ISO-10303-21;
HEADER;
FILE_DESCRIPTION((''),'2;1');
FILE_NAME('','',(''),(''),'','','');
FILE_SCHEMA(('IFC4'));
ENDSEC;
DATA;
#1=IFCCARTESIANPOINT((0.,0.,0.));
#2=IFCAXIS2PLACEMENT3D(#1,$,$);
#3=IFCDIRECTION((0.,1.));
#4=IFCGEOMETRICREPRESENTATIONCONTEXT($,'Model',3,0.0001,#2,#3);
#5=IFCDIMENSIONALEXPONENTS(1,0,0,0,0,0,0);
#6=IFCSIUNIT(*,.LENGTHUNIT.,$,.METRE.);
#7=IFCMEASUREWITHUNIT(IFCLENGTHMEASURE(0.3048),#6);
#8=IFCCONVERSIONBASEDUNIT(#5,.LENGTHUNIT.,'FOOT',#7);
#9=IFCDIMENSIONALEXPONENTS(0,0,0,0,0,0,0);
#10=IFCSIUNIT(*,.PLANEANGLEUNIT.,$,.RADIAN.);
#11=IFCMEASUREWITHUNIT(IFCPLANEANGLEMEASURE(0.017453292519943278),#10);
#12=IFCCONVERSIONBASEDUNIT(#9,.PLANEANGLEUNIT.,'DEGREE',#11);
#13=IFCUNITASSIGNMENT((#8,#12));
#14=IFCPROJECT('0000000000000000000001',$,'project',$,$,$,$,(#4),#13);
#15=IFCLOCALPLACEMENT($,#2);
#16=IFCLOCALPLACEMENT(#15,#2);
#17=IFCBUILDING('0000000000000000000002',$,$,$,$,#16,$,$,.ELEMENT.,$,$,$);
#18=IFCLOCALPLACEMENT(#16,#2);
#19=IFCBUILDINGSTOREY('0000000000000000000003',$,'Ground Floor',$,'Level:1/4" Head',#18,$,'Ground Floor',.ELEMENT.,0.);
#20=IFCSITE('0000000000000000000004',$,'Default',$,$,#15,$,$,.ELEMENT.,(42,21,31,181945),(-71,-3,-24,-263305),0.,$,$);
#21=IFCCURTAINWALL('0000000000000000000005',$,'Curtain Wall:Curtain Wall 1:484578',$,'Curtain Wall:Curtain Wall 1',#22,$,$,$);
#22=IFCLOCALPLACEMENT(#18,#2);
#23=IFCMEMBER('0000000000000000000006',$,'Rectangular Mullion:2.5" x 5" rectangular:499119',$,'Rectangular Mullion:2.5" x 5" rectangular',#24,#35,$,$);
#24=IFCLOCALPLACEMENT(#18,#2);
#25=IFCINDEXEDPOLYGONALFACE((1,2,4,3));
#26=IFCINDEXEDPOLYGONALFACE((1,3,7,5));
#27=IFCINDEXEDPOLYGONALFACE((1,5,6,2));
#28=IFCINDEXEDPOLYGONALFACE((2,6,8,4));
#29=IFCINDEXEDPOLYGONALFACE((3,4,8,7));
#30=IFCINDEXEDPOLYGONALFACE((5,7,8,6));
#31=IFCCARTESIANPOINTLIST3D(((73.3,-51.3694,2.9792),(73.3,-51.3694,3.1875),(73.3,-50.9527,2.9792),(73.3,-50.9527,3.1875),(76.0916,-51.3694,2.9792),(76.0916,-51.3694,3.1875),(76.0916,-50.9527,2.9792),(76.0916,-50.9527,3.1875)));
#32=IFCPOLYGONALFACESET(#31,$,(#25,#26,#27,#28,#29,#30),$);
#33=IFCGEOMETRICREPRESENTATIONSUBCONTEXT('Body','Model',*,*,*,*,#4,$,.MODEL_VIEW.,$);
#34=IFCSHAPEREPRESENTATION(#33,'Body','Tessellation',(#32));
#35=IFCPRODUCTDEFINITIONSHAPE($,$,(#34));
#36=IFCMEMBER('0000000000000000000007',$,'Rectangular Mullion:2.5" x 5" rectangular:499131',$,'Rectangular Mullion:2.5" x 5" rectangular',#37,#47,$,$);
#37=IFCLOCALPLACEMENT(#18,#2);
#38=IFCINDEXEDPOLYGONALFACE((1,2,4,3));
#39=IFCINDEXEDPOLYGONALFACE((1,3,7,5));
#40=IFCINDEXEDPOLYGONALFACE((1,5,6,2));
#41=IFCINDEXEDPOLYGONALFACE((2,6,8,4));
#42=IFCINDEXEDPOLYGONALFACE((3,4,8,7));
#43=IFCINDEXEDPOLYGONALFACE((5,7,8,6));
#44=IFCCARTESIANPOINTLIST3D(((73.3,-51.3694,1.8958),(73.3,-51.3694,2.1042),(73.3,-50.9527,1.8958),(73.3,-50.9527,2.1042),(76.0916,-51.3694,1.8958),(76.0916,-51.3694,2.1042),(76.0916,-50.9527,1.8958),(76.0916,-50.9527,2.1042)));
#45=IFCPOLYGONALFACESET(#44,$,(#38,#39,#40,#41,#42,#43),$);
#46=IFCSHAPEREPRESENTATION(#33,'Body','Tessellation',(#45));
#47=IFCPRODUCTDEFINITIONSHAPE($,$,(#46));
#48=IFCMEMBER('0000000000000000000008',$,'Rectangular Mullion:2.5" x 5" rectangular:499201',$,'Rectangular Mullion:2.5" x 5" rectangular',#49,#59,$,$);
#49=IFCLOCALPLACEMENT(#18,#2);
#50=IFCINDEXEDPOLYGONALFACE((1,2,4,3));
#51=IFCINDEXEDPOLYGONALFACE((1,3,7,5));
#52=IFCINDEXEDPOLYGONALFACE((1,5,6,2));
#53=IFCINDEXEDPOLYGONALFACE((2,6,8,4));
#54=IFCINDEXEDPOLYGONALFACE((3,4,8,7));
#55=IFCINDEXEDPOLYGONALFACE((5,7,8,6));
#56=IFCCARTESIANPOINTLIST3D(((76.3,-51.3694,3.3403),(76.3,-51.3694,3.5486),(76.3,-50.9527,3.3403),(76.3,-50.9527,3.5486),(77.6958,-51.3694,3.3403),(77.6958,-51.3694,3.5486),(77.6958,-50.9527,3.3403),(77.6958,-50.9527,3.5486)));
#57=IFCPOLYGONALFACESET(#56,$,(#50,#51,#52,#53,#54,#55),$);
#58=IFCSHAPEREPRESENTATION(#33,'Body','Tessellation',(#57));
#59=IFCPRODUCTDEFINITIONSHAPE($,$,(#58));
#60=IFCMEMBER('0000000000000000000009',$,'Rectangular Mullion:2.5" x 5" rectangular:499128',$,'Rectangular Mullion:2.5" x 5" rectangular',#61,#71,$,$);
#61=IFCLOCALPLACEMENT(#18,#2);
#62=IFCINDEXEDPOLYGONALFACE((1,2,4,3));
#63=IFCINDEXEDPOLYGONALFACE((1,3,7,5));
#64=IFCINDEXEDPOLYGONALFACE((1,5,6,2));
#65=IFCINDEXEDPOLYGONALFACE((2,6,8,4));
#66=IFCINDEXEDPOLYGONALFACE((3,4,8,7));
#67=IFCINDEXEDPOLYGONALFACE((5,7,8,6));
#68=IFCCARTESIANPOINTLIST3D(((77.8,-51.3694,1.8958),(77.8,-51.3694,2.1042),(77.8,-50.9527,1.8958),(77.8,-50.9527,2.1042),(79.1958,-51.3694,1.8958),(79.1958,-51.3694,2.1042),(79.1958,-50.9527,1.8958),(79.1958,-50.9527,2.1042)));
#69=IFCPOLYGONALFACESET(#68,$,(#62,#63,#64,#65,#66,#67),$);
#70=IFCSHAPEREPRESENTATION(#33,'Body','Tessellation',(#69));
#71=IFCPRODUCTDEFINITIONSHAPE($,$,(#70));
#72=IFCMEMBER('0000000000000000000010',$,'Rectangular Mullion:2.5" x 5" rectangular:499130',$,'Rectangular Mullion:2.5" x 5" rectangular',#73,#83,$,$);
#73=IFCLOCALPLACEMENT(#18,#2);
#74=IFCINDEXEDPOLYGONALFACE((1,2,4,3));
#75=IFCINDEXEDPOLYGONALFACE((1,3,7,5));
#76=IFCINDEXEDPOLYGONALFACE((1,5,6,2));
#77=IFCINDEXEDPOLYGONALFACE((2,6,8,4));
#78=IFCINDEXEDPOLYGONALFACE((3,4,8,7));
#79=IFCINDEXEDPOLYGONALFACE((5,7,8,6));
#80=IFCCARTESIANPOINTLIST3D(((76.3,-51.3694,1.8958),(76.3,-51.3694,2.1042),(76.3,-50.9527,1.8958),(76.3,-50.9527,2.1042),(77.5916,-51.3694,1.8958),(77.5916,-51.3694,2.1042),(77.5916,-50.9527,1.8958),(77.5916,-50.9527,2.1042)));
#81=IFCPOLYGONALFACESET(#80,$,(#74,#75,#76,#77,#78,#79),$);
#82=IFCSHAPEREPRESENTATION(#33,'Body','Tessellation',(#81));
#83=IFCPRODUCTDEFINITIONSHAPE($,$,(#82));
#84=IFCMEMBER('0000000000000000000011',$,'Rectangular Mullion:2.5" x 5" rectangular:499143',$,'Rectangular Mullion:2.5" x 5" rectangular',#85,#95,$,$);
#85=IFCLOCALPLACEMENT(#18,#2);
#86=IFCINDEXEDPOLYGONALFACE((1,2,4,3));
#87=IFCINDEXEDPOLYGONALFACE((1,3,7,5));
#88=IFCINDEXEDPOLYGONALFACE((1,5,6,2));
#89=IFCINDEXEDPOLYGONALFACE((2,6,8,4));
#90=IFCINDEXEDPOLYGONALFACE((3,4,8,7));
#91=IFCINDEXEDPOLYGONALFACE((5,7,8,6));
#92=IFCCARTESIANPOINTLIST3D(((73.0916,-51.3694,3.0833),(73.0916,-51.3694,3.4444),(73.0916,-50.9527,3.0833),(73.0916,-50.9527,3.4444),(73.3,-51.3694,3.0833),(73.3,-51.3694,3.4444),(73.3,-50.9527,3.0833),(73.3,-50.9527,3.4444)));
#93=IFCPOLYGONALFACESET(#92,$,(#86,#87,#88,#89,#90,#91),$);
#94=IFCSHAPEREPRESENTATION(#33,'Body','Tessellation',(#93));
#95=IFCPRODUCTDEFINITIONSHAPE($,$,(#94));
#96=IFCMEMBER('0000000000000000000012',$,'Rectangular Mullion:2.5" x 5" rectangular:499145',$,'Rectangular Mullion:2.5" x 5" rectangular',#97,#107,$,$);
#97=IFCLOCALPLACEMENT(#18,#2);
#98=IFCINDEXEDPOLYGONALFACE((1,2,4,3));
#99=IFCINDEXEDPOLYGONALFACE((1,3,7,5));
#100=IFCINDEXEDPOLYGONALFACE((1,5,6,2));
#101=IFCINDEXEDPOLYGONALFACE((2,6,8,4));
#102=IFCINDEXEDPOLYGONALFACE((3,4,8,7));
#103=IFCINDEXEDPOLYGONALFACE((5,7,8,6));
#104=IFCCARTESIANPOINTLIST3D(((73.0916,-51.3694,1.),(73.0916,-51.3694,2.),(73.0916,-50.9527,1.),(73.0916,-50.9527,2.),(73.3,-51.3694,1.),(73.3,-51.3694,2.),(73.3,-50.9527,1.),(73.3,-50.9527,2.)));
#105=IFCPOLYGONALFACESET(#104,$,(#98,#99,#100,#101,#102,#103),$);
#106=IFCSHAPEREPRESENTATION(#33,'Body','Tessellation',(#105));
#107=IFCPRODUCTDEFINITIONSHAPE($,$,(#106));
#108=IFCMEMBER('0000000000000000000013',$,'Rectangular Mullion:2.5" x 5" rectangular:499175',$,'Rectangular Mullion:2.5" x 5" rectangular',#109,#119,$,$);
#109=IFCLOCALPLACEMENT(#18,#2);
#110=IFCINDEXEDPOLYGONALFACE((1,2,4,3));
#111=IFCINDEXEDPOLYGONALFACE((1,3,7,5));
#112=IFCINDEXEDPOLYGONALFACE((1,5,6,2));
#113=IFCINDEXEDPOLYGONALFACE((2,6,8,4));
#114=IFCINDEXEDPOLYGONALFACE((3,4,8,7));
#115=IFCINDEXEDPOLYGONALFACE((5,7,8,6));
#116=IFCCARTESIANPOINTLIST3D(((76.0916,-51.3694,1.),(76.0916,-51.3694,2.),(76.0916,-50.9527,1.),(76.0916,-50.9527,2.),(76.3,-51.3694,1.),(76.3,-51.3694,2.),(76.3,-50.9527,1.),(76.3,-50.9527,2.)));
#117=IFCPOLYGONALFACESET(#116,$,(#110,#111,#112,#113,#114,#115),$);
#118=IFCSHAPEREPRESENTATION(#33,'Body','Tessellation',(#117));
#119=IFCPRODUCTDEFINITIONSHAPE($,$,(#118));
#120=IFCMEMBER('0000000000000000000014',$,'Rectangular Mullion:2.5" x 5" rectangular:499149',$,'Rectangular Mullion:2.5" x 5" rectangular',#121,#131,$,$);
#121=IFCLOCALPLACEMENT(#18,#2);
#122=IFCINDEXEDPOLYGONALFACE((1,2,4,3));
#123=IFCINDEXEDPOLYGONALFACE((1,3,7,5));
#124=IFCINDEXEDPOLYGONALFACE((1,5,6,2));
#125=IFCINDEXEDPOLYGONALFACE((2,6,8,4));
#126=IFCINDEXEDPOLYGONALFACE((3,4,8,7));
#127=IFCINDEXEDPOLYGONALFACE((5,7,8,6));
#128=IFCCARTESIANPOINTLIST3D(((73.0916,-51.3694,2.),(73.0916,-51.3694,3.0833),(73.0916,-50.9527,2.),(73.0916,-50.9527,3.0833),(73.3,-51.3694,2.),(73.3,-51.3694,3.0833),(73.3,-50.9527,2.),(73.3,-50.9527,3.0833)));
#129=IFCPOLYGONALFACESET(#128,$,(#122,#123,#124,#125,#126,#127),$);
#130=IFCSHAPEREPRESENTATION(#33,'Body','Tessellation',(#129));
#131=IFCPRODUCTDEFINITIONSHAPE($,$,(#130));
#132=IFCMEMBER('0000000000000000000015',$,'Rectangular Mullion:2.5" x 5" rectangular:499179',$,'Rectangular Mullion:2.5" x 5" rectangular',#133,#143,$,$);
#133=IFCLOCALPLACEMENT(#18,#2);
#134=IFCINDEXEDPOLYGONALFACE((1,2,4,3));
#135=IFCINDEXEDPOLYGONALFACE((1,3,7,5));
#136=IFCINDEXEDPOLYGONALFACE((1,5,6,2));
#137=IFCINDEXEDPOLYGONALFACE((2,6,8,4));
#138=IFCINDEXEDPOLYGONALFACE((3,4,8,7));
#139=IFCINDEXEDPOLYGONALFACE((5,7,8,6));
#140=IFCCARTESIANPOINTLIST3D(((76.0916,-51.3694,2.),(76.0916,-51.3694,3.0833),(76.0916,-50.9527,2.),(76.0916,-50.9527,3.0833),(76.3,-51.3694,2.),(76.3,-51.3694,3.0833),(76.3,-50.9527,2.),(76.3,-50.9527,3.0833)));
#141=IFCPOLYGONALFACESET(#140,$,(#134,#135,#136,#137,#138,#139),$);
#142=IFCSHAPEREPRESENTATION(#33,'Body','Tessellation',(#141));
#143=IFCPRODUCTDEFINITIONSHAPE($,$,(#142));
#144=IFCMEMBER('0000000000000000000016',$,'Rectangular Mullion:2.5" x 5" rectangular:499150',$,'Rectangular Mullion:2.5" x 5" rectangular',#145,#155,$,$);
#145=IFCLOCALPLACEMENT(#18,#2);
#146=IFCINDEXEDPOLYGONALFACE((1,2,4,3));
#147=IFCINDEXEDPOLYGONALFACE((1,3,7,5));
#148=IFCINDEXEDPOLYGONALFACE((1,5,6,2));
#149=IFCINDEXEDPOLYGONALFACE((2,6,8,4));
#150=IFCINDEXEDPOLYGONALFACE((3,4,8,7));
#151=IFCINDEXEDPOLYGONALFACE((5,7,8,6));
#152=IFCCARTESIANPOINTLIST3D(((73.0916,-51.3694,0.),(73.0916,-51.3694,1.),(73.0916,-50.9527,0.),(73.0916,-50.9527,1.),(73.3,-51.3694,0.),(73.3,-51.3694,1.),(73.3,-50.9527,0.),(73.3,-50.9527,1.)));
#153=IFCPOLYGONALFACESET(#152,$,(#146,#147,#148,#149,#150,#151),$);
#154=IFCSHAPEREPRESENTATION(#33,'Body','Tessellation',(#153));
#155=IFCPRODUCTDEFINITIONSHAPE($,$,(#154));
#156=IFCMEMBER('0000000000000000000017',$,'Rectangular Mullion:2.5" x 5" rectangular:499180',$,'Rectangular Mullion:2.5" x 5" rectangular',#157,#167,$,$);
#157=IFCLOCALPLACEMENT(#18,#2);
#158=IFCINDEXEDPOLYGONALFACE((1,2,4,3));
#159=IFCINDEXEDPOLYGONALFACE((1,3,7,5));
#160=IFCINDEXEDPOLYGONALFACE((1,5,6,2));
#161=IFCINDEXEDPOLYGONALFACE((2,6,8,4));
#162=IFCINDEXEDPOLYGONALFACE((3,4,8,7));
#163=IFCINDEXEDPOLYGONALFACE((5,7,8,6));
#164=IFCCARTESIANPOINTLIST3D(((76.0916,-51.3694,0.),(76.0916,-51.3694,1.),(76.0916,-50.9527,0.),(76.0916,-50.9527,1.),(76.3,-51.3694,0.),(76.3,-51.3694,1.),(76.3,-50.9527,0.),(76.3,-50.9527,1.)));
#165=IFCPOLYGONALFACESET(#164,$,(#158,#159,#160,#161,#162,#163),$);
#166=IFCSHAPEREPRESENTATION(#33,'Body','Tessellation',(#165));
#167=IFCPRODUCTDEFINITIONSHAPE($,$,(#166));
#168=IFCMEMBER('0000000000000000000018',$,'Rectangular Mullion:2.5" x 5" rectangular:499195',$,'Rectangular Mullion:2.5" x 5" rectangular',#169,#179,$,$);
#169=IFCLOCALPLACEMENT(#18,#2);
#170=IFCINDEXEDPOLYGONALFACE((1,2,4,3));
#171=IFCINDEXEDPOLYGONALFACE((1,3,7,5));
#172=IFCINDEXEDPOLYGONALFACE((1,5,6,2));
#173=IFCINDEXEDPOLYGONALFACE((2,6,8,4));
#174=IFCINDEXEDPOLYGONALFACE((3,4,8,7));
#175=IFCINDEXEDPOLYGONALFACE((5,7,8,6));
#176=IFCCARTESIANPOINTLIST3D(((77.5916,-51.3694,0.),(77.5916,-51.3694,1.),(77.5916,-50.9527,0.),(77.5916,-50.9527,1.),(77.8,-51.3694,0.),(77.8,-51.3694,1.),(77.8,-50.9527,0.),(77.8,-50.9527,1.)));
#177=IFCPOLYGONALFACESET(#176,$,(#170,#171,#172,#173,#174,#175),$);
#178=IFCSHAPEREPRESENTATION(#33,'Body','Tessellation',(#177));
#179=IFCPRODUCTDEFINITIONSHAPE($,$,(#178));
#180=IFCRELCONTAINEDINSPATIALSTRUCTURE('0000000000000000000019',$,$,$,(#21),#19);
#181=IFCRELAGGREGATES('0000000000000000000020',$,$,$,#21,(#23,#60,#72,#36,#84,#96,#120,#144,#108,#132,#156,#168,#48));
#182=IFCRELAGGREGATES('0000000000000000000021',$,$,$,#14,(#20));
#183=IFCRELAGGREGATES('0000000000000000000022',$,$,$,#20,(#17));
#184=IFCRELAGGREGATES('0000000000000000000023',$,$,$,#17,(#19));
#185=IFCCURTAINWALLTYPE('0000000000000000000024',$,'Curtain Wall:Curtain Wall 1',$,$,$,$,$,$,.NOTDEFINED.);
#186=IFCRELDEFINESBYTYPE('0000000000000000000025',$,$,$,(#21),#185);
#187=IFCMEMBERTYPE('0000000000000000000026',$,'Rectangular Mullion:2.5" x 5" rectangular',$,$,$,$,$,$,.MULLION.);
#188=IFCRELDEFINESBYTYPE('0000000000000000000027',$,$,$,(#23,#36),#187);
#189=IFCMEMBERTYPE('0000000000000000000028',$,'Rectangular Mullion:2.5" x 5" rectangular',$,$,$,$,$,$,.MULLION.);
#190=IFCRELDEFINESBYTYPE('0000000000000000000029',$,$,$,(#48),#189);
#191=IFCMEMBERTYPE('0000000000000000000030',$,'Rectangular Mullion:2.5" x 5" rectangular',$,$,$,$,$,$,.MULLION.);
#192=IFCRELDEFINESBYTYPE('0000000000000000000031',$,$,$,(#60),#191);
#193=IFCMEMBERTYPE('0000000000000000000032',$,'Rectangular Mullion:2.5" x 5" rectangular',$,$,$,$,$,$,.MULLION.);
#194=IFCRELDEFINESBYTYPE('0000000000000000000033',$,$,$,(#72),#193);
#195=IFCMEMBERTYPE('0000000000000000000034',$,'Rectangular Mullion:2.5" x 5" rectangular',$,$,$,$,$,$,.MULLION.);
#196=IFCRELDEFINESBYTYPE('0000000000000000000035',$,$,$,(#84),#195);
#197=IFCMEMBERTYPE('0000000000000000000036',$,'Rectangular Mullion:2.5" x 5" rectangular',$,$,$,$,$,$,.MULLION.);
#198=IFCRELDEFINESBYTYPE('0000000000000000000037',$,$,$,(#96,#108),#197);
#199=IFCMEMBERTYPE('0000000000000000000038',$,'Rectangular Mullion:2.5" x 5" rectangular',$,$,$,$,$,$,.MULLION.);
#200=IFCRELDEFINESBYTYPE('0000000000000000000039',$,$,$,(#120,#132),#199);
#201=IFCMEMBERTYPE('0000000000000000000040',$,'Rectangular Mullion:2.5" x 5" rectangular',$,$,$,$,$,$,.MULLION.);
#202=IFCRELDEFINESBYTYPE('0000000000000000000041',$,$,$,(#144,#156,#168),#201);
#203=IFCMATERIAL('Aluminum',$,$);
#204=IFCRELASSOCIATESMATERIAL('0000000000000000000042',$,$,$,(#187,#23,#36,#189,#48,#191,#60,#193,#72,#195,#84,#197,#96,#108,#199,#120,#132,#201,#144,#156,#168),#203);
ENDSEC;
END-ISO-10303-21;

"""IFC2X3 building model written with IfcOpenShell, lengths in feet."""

from ifc_helpers import new_model, entity, si_unit, converted_unit, direction, frame, origin, origin_2d_with_axis, place, context, subcontext, project, spatial, rectangle, extrude, source, transform, mapped, material, type_object, type_shapes, element, aggregate, save


model = new_model("IFC2X3")

# Units and contexts
model_context = context("Model", 3, precision=0.0001, world=origin(), true_north=direction((0.0, 1.0)))
body_context = subcontext(model_context, "Body", "Model", "MODEL_VIEW")
ifc_project = project(units=[converted_unit("LENGTHUNIT", "FOOT", entity("IfcLengthMeasure", 0.3048), si_unit("LENGTHUNIT", "METRE"), dimensions=[1, 0, 0, 0, 0, 0, 0]), converted_unit("PLANEANGLEUNIT", "DEGREE", entity("IfcPlaneAngleMeasure", 0.017453292519943278), si_unit("PLANEANGLEUNIT", "RADIAN"), dimensions=[0, 0, 0, 0, 0, 0, 0])], contexts=[model_context])

# Site, building, storey
site_placement = place(None, origin())
site = spatial("IfcSite", under=ifc_project, at=site_placement, Name="Default", CompositionType="ELEMENT", RefLatitude=(42, 21, 31, 181945), RefLongitude=(-71, -3, -24, -263305), RefElevation=0.0)
building_placement = place(site_placement, origin())
building = spatial("IfcBuilding", under=site, at=building_placement, CompositionType="ELEMENT")
storey_placement = place(building_placement, origin())
storey = spatial("IfcBuildingStorey", under=building, at=storey_placement, Name="Ground Floor", ObjectType="Level:1/4\" Head", LongName="Ground Floor", CompositionType="ELEMENT", Elevation=0.0)

# Curtain wall, members
curtain_wall_type = type_object("IfcCurtainWallType", Name="Curtain Wall:Curtain Wall 1", PredefinedType="NOTDEFINED")
curtain_wall_placement = place(storey_placement, origin())
curtain_wall = element("IfcCurtainWall", 1, at=curtain_wall_placement, inside=storey, type_object=curtain_wall_type, Name="Curtain Wall:Curtain Wall 1:484578", ObjectType="Curtain Wall:Curtain Wall 1")
ifc_material_1 = material(Name="Aluminum")
member_type_1 = type_object("IfcMemberType", Name="Rectangular Mullion:2.5\" x 5\" rectangular", PredefinedType="MULLION", material=ifc_material_1)
shared_shape_1 = source(origin(), body_context, "Body", "SweptSolid", [
    extrude(rectangle(XDim=0.2083, YDim=0.4167, at=origin_2d_with_axis()), frame((0.0, 0.0, -2.7917), z_axis=(0.0, 0.0, 1.0), x_axis=(-1.0, 0.0, 0.0)), (0.0, 0.0, 1.0), 2.7917),
])
type_shapes(member_type_1, [shared_shape_1])
member_1_placement = place(curtain_wall_placement, frame((76.0916, -51.161, 3.0833), z_axis=(1.0, 0.0, 0.0), x_axis=(0.0, 0.0, 1.0)))
member_1 = element("IfcMember", 2, at=member_1_placement, type_object=member_type_1, material=ifc_material_1, Name="Rectangular Mullion:2.5\" x 5\" rectangular:499119", ObjectType="Rectangular Mullion:2.5\" x 5\" rectangular", context=body_context, shape_type="MappedRepresentation", body=[
    mapped(shared_shape_1, transform((0.0, 0.0, 0.0), scale=1.0)),
])
member_2_placement = place(curtain_wall_placement, frame((76.0916, -51.161, 2.0), z_axis=(1.0, 0.0, 0.0), x_axis=(0.0, 0.0, 1.0)))
member_2 = element("IfcMember", 3, at=member_2_placement, type_object=member_type_1, material=ifc_material_1, Name="Rectangular Mullion:2.5\" x 5\" rectangular:499131", ObjectType="Rectangular Mullion:2.5\" x 5\" rectangular", context=body_context, shape_type="MappedRepresentation", body=[
    mapped(shared_shape_1, transform((0.0, 0.0, 0.0), scale=1.0)),
])
member_type_2 = type_object("IfcMemberType", Name="Rectangular Mullion:2.5\" x 5\" rectangular", PredefinedType="MULLION", material=ifc_material_1)
shared_shape_2 = source(origin(), body_context, "Body", "SweptSolid", [
    extrude(rectangle(XDim=0.2083, YDim=0.4167, at=origin_2d_with_axis()), frame((0.0, 0.0, -1.3958), z_axis=(0.0, 0.0, 1.0), x_axis=(-1.0, 0.0, 0.0)), (0.0, 0.0, 1.0), 1.3958),
])
type_shapes(member_type_2, [shared_shape_2])
member_3_placement = place(curtain_wall_placement, frame((77.6958, -51.161, 3.4444), z_axis=(1.0, 0.0, 0.0), x_axis=(0.0, 0.0, 1.0)))
member_3 = element("IfcMember", 4, at=member_3_placement, type_object=member_type_2, material=ifc_material_1, Name="Rectangular Mullion:2.5\" x 5\" rectangular:499201", ObjectType="Rectangular Mullion:2.5\" x 5\" rectangular", context=body_context, shape_type="MappedRepresentation", body=[
    mapped(shared_shape_2, transform((0.0, 0.0, 0.0), scale=1.0)),
])
member_type_3 = type_object("IfcMemberType", Name="Rectangular Mullion:2.5\" x 5\" rectangular", PredefinedType="MULLION", material=ifc_material_1)
shared_shape_3 = source(origin(), body_context, "Body", "SweptSolid", [
    extrude(rectangle(XDim=0.2083, YDim=0.4167, at=origin_2d_with_axis()), frame((0.0, 0.0, -1.3958), z_axis=(0.0, 0.0, 1.0), x_axis=(-1.0, 0.0, 0.0)), (0.0, 0.0, 1.0), 1.3958),
])
type_shapes(member_type_3, [shared_shape_3])
member_4_placement = place(curtain_wall_placement, frame((79.1958, -51.161, 2.0), z_axis=(1.0, 0.0, 0.0), x_axis=(0.0, 0.0, 1.0)))
member_4 = element("IfcMember", 5, at=member_4_placement, type_object=member_type_3, material=ifc_material_1, Name="Rectangular Mullion:2.5\" x 5\" rectangular:499128", ObjectType="Rectangular Mullion:2.5\" x 5\" rectangular", context=body_context, shape_type="MappedRepresentation", body=[
    mapped(shared_shape_3, transform((0.0, 0.0, 0.0), scale=1.0)),
])
member_type_4 = type_object("IfcMemberType", Name="Rectangular Mullion:2.5\" x 5\" rectangular", PredefinedType="MULLION", material=ifc_material_1)
shared_shape_4 = source(origin(), body_context, "Body", "SweptSolid", [
    extrude(rectangle(XDim=0.2083, YDim=0.4167, at=origin_2d_with_axis()), frame((0.0, 0.0, -1.2917), z_axis=(0.0, 0.0, 1.0), x_axis=(-1.0, 0.0, 0.0)), (0.0, 0.0, 1.0), 1.2917),
])
type_shapes(member_type_4, [shared_shape_4])
member_5_placement = place(curtain_wall_placement, frame((77.5916, -51.161, 2.0), z_axis=(1.0, 0.0, 0.0), x_axis=(0.0, 0.0, 1.0)))
member_5 = element("IfcMember", 6, at=member_5_placement, type_object=member_type_4, material=ifc_material_1, Name="Rectangular Mullion:2.5\" x 5\" rectangular:499130", ObjectType="Rectangular Mullion:2.5\" x 5\" rectangular", context=body_context, shape_type="MappedRepresentation", body=[
    mapped(shared_shape_4, transform((0.0, 0.0, 0.0), scale=1.0)),
])
member_type_5 = type_object("IfcMemberType", Name="Rectangular Mullion:2.5\" x 5\" rectangular", PredefinedType="MULLION", material=ifc_material_1)
shared_shape_5 = source(origin(), body_context, "Body", "SweptSolid", [
    extrude(rectangle(XDim=0.2083, YDim=0.4167, at=origin_2d_with_axis()), frame((0.0, 0.0, -0.3611), z_axis=(0.0, 0.0, 1.0), x_axis=(-1.0, 0.0, 0.0)), (0.0, 0.0, 1.0), 0.3611),
])
type_shapes(member_type_5, [shared_shape_5])
member_6_placement = place(curtain_wall_placement, frame((73.1958, -51.161, 3.0833), z_axis=(0.0, 0.0, -1.0), x_axis=(1.0, 0.0, 0.0)))
member_6 = element("IfcMember", 7, at=member_6_placement, type_object=member_type_5, material=ifc_material_1, Name="Rectangular Mullion:2.5\" x 5\" rectangular:499143", ObjectType="Rectangular Mullion:2.5\" x 5\" rectangular", context=body_context, shape_type="MappedRepresentation", body=[
    mapped(shared_shape_5, transform((0.0, 0.0, 0.0), scale=1.0)),
])
member_type_6 = type_object("IfcMemberType", Name="Rectangular Mullion:2.5\" x 5\" rectangular", PredefinedType="MULLION", material=ifc_material_1)
shared_shape_6 = source(origin(), body_context, "Body", "SweptSolid", [
    extrude(rectangle(XDim=0.2083, YDim=0.4167, at=origin_2d_with_axis()), frame((0.0, 0.0, -1.0), z_axis=(0.0, 0.0, 1.0), x_axis=(-1.0, 0.0, 0.0)), (0.0, 0.0, 1.0), 1.0),
])
type_shapes(member_type_6, [shared_shape_6])
member_7_placement = place(curtain_wall_placement, frame((73.1958, -51.161, 1.0), z_axis=(0.0, 0.0, -1.0), x_axis=(1.0, 0.0, 0.0)))
member_7 = element("IfcMember", 8, at=member_7_placement, type_object=member_type_6, material=ifc_material_1, Name="Rectangular Mullion:2.5\" x 5\" rectangular:499145", ObjectType="Rectangular Mullion:2.5\" x 5\" rectangular", context=body_context, shape_type="MappedRepresentation", body=[
    mapped(shared_shape_6, transform((0.0, 0.0, 0.0), scale=1.0)),
])
member_8_placement = place(curtain_wall_placement, frame((76.1958, -51.161, 1.0), z_axis=(0.0, 0.0, -1.0), x_axis=(1.0, 0.0, 0.0)))
member_8 = element("IfcMember", 9, at=member_8_placement, type_object=member_type_6, material=ifc_material_1, Name="Rectangular Mullion:2.5\" x 5\" rectangular:499175", ObjectType="Rectangular Mullion:2.5\" x 5\" rectangular", context=body_context, shape_type="MappedRepresentation", body=[
    mapped(shared_shape_6, transform((0.0, 0.0, 0.0), scale=1.0)),
])
member_type_7 = type_object("IfcMemberType", Name="Rectangular Mullion:2.5\" x 5\" rectangular", PredefinedType="MULLION", material=ifc_material_1)
shared_shape_7 = source(origin(), body_context, "Body", "SweptSolid", [
    extrude(rectangle(XDim=0.2083, YDim=0.4167, at=origin_2d_with_axis()), frame((0.0, 0.0, -1.0833), z_axis=(0.0, 0.0, 1.0), x_axis=(-1.0, 0.0, 0.0)), (0.0, 0.0, 1.0), 1.0833),
])
type_shapes(member_type_7, [shared_shape_7])
member_9_placement = place(curtain_wall_placement, frame((73.1958, -51.161, 2.0), z_axis=(0.0, 0.0, -1.0), x_axis=(1.0, 0.0, 0.0)))
member_9 = element("IfcMember", 10, at=member_9_placement, type_object=member_type_7, material=ifc_material_1, Name="Rectangular Mullion:2.5\" x 5\" rectangular:499149", ObjectType="Rectangular Mullion:2.5\" x 5\" rectangular", context=body_context, shape_type="MappedRepresentation", body=[
    mapped(shared_shape_7, transform((0.0, 0.0, 0.0), scale=1.0)),
])
member_10_placement = place(curtain_wall_placement, frame((76.1958, -51.161, 2.0), z_axis=(0.0, 0.0, -1.0), x_axis=(1.0, 0.0, 0.0)))
member_10 = element("IfcMember", 11, at=member_10_placement, type_object=member_type_7, material=ifc_material_1, Name="Rectangular Mullion:2.5\" x 5\" rectangular:499179", ObjectType="Rectangular Mullion:2.5\" x 5\" rectangular", context=body_context, shape_type="MappedRepresentation", body=[
    mapped(shared_shape_7, transform((0.0, 0.0, 0.0), scale=1.0)),
])
member_type_8 = type_object("IfcMemberType", Name="Rectangular Mullion:2.5\" x 5\" rectangular", PredefinedType="MULLION", material=ifc_material_1)
shared_shape_8 = source(origin(), body_context, "Body", "SweptSolid", [
    extrude(rectangle(XDim=0.2083, YDim=0.4167, at=origin_2d_with_axis()), frame((0.0, 0.0, -1.0), z_axis=(0.0, 0.0, 1.0), x_axis=(-1.0, 0.0, 0.0)), (0.0, 0.0, 1.0), 1.0),
])
type_shapes(member_type_8, [shared_shape_8])
member_11_placement = place(curtain_wall_placement, frame((73.1958, -51.161, 0.0), z_axis=(0.0, 0.0, -1.0), x_axis=(1.0, 0.0, 0.0)))
member_11 = element("IfcMember", 12, at=member_11_placement, type_object=member_type_8, material=ifc_material_1, Name="Rectangular Mullion:2.5\" x 5\" rectangular:499150", ObjectType="Rectangular Mullion:2.5\" x 5\" rectangular", context=body_context, shape_type="MappedRepresentation", body=[
    mapped(shared_shape_8, transform((0.0, 0.0, 0.0), scale=1.0)),
])
member_12_placement = place(curtain_wall_placement, frame((76.1958, -51.161, 0.0), z_axis=(0.0, 0.0, -1.0), x_axis=(1.0, 0.0, 0.0)))
member_12 = element("IfcMember", 13, at=member_12_placement, type_object=member_type_8, material=ifc_material_1, Name="Rectangular Mullion:2.5\" x 5\" rectangular:499180", ObjectType="Rectangular Mullion:2.5\" x 5\" rectangular", context=body_context, shape_type="MappedRepresentation", body=[
    mapped(shared_shape_8, transform((0.0, 0.0, 0.0), scale=1.0)),
])
member_13_placement = place(curtain_wall_placement, frame((77.6958, -51.161, 0.0), z_axis=(0.0, 0.0, -1.0), x_axis=(1.0, 0.0, 0.0)))
member_13 = element("IfcMember", 14, at=member_13_placement, type_object=member_type_8, material=ifc_material_1, Name="Rectangular Mullion:2.5\" x 5\" rectangular:499195", ObjectType="Rectangular Mullion:2.5\" x 5\" rectangular", context=body_context, shape_type="MappedRepresentation", body=[
    mapped(shared_shape_8, transform((0.0, 0.0, 0.0), scale=1.0)),
])
aggregate(curtain_wall, [member_1, member_4, member_5, member_2, member_6, member_7, member_9, member_11, member_8, member_10, member_12, member_13, member_3])

save(model, "model.ifc")
